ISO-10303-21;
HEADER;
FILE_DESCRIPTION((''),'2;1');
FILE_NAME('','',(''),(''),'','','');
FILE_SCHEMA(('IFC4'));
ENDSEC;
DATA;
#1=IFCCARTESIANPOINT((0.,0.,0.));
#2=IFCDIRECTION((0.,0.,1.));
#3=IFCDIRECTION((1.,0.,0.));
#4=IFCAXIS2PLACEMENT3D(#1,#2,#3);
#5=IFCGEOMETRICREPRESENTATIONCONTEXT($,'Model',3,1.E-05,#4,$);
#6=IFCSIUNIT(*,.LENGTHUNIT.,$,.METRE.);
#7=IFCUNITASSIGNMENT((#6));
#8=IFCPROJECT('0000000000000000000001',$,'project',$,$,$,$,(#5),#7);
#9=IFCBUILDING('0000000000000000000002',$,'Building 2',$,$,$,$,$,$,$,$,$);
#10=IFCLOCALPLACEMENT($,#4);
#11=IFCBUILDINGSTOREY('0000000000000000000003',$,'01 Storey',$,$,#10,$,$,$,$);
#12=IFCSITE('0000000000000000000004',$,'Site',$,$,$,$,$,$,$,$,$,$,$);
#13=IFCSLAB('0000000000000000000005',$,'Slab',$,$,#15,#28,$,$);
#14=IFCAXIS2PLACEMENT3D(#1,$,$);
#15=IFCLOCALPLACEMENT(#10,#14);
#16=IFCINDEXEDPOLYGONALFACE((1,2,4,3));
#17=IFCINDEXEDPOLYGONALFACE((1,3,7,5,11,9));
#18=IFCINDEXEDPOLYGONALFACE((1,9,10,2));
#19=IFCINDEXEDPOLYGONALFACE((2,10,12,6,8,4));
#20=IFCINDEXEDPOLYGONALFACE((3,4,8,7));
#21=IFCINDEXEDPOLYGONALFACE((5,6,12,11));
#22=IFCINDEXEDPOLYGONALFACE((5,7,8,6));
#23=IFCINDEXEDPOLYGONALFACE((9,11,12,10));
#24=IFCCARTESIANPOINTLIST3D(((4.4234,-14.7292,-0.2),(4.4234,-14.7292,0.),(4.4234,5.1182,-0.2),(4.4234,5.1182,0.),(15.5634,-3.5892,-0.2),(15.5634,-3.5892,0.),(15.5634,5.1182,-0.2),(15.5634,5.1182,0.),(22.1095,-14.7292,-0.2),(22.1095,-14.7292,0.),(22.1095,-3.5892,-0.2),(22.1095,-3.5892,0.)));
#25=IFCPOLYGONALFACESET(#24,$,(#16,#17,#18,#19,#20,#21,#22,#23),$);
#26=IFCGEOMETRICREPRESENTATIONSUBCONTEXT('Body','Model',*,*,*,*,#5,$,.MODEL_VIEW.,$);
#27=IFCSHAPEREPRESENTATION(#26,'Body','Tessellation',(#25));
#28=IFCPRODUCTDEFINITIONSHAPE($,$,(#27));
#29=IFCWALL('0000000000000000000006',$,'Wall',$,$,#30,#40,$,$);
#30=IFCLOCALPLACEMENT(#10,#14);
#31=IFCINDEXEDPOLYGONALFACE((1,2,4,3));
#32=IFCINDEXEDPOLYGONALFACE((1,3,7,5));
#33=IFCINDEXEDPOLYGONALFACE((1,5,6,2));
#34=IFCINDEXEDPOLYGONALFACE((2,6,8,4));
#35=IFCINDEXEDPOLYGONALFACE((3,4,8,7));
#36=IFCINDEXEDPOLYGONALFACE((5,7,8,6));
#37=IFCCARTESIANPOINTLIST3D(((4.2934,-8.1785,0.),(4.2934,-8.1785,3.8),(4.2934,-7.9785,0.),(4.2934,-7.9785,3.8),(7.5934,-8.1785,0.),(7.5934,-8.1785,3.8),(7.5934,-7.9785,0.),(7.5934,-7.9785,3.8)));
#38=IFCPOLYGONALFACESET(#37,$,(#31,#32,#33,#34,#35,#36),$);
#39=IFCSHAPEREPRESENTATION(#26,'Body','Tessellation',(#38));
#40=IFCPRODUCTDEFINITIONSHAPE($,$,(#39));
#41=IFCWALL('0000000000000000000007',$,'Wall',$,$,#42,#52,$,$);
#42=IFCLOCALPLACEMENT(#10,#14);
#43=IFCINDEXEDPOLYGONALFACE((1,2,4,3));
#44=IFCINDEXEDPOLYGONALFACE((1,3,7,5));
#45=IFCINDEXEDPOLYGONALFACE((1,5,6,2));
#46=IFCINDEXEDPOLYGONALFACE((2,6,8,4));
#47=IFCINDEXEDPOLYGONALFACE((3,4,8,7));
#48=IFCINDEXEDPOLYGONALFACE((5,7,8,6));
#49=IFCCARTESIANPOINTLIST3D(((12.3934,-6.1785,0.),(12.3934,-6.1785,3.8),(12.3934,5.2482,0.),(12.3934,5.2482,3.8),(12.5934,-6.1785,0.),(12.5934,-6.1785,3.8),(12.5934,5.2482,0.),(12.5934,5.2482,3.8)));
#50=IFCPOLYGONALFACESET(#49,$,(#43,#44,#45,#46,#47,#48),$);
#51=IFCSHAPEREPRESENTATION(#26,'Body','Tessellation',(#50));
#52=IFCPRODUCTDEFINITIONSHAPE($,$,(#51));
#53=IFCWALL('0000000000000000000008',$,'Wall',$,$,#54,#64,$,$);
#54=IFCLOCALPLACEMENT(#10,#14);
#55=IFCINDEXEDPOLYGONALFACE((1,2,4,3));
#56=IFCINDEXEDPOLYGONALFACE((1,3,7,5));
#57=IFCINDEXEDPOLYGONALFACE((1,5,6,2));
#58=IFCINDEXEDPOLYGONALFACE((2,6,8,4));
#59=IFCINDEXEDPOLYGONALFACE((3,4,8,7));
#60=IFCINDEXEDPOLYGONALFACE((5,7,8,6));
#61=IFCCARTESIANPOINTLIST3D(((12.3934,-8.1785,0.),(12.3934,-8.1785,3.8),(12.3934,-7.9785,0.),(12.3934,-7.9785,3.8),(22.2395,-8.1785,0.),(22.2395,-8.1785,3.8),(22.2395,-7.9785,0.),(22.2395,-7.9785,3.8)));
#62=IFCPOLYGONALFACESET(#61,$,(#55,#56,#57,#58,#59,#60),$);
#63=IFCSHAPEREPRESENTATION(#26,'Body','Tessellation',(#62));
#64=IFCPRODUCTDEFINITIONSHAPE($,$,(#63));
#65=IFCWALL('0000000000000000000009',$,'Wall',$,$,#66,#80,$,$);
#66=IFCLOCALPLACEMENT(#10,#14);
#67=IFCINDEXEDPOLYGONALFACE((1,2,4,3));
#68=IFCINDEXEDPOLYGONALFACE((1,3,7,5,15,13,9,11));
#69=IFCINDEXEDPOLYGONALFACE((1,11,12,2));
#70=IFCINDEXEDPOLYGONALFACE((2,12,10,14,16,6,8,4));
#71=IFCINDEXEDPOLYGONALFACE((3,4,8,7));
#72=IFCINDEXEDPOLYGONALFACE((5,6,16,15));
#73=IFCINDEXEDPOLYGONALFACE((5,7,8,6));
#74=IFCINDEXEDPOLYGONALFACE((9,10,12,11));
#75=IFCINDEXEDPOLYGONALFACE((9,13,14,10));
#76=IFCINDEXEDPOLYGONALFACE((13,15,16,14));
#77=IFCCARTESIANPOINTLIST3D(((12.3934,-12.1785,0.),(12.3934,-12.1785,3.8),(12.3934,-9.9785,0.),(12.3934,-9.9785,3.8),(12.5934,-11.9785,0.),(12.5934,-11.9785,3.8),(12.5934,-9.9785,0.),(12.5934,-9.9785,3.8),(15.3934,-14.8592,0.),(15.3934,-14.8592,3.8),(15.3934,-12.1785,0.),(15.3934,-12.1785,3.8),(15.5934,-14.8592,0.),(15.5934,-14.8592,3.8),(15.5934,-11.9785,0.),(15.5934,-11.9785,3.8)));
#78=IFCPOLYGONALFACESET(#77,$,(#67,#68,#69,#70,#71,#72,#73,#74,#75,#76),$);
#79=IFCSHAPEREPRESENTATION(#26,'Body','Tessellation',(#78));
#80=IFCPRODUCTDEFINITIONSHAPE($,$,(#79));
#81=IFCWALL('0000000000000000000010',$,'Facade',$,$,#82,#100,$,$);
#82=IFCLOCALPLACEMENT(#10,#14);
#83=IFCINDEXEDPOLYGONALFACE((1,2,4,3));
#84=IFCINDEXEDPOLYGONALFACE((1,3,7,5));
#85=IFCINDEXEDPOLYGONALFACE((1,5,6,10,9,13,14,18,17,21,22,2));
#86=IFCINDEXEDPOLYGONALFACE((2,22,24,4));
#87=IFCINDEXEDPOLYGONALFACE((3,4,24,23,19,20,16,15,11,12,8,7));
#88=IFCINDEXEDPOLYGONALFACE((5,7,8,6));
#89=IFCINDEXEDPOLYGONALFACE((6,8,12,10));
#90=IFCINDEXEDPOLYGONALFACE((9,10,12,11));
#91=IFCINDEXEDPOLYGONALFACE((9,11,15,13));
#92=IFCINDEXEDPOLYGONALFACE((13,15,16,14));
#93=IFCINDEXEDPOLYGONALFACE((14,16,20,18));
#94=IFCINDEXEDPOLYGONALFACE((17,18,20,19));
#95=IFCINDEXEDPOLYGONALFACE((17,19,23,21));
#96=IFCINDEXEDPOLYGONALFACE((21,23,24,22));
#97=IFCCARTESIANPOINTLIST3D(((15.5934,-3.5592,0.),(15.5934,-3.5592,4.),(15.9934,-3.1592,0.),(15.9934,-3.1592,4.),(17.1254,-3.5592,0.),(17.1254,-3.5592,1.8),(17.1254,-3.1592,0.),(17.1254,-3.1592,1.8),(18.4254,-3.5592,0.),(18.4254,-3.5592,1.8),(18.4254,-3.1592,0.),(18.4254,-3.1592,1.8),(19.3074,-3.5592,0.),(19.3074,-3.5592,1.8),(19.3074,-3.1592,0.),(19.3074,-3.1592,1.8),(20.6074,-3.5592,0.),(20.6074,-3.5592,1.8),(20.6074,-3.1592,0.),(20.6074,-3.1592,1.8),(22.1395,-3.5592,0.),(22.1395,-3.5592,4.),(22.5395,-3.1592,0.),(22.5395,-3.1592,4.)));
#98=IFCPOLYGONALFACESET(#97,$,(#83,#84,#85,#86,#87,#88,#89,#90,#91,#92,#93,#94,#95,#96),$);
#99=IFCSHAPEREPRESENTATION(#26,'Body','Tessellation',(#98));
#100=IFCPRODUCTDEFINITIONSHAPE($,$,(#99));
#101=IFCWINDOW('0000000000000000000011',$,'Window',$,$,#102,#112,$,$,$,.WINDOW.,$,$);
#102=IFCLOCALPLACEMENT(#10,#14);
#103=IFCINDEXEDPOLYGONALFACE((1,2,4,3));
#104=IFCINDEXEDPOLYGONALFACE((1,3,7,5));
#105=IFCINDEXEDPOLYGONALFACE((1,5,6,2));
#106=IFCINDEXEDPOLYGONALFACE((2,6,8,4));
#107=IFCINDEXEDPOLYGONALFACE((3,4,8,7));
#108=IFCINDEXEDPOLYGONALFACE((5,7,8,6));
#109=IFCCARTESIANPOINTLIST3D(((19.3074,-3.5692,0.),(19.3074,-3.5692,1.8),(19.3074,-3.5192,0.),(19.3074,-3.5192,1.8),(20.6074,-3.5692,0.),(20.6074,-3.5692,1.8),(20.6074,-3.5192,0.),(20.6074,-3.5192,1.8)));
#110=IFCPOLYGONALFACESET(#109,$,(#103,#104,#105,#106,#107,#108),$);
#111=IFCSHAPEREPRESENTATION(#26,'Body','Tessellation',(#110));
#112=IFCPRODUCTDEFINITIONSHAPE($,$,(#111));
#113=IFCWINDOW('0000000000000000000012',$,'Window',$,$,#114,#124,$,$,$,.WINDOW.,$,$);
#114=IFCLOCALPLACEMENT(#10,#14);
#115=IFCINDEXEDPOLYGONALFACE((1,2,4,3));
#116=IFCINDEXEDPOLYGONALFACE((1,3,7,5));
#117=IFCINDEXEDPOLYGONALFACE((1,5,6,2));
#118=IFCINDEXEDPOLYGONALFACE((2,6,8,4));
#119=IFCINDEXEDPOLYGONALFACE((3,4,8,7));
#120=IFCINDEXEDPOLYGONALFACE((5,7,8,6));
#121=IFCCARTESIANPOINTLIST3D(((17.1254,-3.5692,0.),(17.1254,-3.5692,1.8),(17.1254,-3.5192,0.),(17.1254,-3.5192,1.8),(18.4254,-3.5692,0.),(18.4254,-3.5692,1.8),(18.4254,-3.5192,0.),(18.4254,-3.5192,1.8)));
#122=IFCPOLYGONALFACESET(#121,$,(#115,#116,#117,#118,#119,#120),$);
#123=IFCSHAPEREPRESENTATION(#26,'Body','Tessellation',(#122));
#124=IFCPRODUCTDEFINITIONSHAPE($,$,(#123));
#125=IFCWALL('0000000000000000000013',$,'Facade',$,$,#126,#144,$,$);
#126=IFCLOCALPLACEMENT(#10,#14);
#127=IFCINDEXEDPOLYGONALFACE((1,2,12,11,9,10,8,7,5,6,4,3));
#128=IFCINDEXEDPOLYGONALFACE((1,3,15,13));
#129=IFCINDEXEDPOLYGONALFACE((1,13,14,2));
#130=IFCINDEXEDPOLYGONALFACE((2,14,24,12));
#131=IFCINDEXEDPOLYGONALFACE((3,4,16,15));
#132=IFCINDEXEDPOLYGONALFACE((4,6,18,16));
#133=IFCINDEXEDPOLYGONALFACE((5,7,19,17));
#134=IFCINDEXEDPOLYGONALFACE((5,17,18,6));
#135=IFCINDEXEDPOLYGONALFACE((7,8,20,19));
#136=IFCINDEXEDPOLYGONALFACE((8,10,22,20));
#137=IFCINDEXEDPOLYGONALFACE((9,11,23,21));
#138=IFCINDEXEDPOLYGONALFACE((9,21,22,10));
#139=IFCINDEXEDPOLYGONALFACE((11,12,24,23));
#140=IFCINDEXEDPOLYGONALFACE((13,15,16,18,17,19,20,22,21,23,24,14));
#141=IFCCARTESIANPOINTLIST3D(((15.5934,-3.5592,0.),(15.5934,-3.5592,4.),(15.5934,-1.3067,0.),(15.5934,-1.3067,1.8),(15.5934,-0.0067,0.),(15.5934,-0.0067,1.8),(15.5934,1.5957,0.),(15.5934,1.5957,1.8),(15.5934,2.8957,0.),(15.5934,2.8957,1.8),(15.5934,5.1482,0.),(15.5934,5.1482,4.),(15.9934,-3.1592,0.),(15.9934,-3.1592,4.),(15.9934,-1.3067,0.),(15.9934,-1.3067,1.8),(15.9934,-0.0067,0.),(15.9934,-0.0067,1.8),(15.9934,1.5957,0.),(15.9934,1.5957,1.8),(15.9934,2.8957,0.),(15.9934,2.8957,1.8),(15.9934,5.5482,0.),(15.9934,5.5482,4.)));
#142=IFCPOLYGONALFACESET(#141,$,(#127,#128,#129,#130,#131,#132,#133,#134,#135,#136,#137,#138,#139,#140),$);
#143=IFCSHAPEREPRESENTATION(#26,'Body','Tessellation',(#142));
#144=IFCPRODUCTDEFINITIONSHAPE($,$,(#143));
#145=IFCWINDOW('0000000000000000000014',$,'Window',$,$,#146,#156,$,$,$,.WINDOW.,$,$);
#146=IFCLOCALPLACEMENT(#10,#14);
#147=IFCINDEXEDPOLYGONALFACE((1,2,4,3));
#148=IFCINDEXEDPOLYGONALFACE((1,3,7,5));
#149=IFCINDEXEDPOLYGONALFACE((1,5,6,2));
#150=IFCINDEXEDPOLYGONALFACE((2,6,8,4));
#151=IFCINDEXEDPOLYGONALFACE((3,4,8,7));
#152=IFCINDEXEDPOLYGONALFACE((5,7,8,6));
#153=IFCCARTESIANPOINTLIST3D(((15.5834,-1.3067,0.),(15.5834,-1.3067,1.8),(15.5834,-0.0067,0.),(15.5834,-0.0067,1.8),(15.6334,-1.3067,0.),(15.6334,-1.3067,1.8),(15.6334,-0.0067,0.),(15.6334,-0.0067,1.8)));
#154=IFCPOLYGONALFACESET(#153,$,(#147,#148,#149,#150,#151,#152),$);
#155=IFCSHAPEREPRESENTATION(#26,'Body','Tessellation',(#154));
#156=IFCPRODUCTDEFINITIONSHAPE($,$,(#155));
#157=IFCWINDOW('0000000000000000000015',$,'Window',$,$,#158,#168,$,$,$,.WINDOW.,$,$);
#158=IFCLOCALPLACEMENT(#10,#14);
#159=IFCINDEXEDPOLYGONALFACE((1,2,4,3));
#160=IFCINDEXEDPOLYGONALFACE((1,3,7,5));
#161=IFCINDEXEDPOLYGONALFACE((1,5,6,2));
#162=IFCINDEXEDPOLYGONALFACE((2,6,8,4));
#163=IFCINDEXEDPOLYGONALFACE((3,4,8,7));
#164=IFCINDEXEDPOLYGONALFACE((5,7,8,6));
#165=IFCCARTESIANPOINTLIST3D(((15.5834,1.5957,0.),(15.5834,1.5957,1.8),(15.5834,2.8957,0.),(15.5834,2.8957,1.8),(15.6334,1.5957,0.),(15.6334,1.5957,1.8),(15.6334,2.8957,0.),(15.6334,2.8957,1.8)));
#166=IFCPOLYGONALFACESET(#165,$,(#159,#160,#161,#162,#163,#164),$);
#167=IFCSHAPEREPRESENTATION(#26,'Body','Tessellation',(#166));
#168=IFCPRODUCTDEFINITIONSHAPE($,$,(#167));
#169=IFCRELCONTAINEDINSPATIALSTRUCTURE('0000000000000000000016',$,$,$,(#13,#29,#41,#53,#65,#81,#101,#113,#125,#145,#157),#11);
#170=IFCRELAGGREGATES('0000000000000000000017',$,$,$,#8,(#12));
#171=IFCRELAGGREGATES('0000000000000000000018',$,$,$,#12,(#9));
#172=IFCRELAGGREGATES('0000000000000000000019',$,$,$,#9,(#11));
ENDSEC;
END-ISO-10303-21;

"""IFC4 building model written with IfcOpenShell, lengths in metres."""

from ifc_helpers import new_model, si_unit, origin_with_axes, place, context, subcontext, project, spatial, line, indexed_curve, outline, extrude, element, fill, save


model = new_model("IFC4")

# Units and contexts
model_context = context("Model", 3, precision=1e-05, world=origin_with_axes())
body_context = subcontext(model_context, "Body", "Model", "MODEL_VIEW")
ifc_project = project(units=[si_unit("LENGTHUNIT", "METRE")], contexts=[model_context])

# Site, building, storey
site = spatial("IfcSite", under=ifc_project, Name="Site")
building = spatial("IfcBuilding", under=site, Name="Building 2")
storey_placement = place(None, origin_with_axes())
storey = spatial("IfcBuildingStorey", under=building, at=storey_placement, Name="01 Storey")

# Slab
slab_placement = place(storey_placement, origin_with_axes())
element("IfcSlab", 1, at=slab_placement, inside=storey, Name="Slab", context=body_context, shape_type="SweptSolid", body=[
    extrude(outline(indexed_curve([(22.1095, -3.5892), (15.5634, -3.5892), (15.5634, 5.1182), (4.4234, 5.1182), (4.4234, -14.7292), (22.1095, -14.7292)], segments=[line(1, 2), line(2, 3), line(3, 4), line(4, 5), line(5, 6)])), origin_with_axes(), (0.0, 0.0, -1.0), 0.2),
])

# Walls
wall_1_placement = place(storey_placement, origin_with_axes())
element("IfcWall", 2, at=wall_1_placement, inside=storey, Name="Wall", context=body_context, shape_type="SweptSolid", body=[
    extrude(outline(indexed_curve([(7.5934, -7.9785), (4.2934, -7.9785), (4.2934, -8.1785), (7.5934, -8.1785)], segments=[line(1, 2), line(2, 3), line(3, 4)])), origin_with_axes(), (0.0, 0.0, 1.0), 3.8),
])
wall_2_placement = place(storey_placement, origin_with_axes())
element("IfcWall", 3, at=wall_2_placement, inside=storey, Name="Wall", context=body_context, shape_type="SweptSolid", body=[
    extrude(outline(indexed_curve([(12.5934, 5.2482), (12.3934, 5.2482), (12.3934, -6.1785), (12.5934, -6.1785)], segments=[line(1, 2), line(2, 3), line(3, 4)])), origin_with_axes(), (0.0, 0.0, 1.0), 3.8),
])
wall_3_placement = place(storey_placement, origin_with_axes())
element("IfcWall", 4, at=wall_3_placement, inside=storey, Name="Wall", context=body_context, shape_type="SweptSolid", body=[
    extrude(outline(indexed_curve([(22.2395, -7.9785), (12.3934, -7.9785), (12.3934, -8.1785), (22.2395, -8.1785)], segments=[line(1, 2), line(2, 3), line(3, 4)])), origin_with_axes(), (0.0, 0.0, 1.0), 3.8),
])
wall_4_placement = place(storey_placement, origin_with_axes())
element("IfcWall", 5, at=wall_4_placement, inside=storey, Name="Wall", context=body_context, shape_type="SweptSolid", body=[
    extrude(outline(indexed_curve([(15.5934, -11.9785), (12.5934, -11.9785), (12.5934, -9.9785), (12.3934, -9.9785), (12.3934, -12.1785), (15.3934, -12.1785), (15.3934, -14.8592), (15.5934, -14.8592)], segments=[line(1, 2), line(2, 3), line(3, 4), line(4, 5), line(5, 6), line(6, 7), line(7, 8)])), origin_with_axes(), (0.0, 0.0, 1.0), 3.8),
])

# Walls, openings, windows
wall_5_placement = place(storey_placement, origin_with_axes())
wall_5 = element("IfcWall", 6, at=wall_5_placement, inside=storey, Name="Facade", context=body_context, shape_type="SweptSolid", body=[
    extrude(outline(indexed_curve([(22.1395, -3.5592), (15.5934, -3.5592), (15.9934, -3.1592), (22.5395, -3.1592)], segments=[line(1, 2), line(2, 3), line(3, 4)])), origin_with_axes(), (0.0, 0.0, 1.0), 4.0),
])
opening_1_placement = place(wall_5_placement, origin_with_axes())
opening_1 = element("IfcOpeningElement", 7, at=opening_1_placement, cuts=wall_5, context=body_context, shape_type="SweptSolid", body=[
    extrude(outline(indexed_curve([(20.6074, -3.1192), (20.6074, -3.6192), (19.3074, -3.6192), (19.3074, -3.1192)], segments=[line(1, 2), line(2, 3), line(3, 4)])), origin_with_axes(), (0.0, 0.0, 1.0), 1.8),
])
opening_2_placement = place(wall_5_placement, origin_with_axes())
opening_2 = element("IfcOpeningElement", 8, at=opening_2_placement, cuts=wall_5, context=body_context, shape_type="SweptSolid", body=[
    extrude(outline(indexed_curve([(18.4254, -3.1192), (18.4254, -3.6192), (17.1254, -3.6192), (17.1254, -3.1192)], segments=[line(1, 2), line(2, 3), line(3, 4)])), origin_with_axes(), (0.0, 0.0, 1.0), 1.8),
])
window_1_placement = place(storey_placement, origin_with_axes())
window_1 = element("IfcWindow", 9, at=window_1_placement, inside=storey, Name="Window", PredefinedType="WINDOW", context=body_context, shape_type="SweptSolid", body=[
    extrude(outline(indexed_curve([(20.6074, -3.5192), (20.6074, -3.5692), (19.3074, -3.5692), (19.3074, -3.5192)], segments=[line(1, 2), line(2, 3), line(3, 4)])), origin_with_axes(), (0.0, 0.0, 1.0), 1.8),
])
fill(opening_1, window_1)
window_2_placement = place(storey_placement, origin_with_axes())
window_2 = element("IfcWindow", 10, at=window_2_placement, inside=storey, Name="Window", PredefinedType="WINDOW", context=body_context, shape_type="SweptSolid", body=[
    extrude(outline(indexed_curve([(18.4254, -3.5192), (18.4254, -3.5692), (17.1254, -3.5692), (17.1254, -3.5192)], segments=[line(1, 2), line(2, 3), line(3, 4)])), origin_with_axes(), (0.0, 0.0, 1.0), 1.8),
])
fill(opening_2, window_2)
wall_6_placement = place(storey_placement, origin_with_axes())
wall_6 = element("IfcWall", 11, at=wall_6_placement, inside=storey, Name="Facade", context=body_context, shape_type="SweptSolid", body=[
    extrude(outline(indexed_curve([(15.5934, -3.5592), (15.5934, 5.1482), (15.9934, 5.5482), (15.9934, -3.1592)], segments=[line(1, 2), line(2, 3), line(3, 4)])), origin_with_axes(), (0.0, 0.0, 1.0), 4.0),
])
opening_3_placement = place(wall_6_placement, origin_with_axes())
opening_3 = element("IfcOpeningElement", 12, at=opening_3_placement, cuts=wall_6, context=body_context, shape_type="SweptSolid", body=[
    extrude(outline(indexed_curve([(16.0334, -1.3067), (15.5334, -1.3067), (15.5334, -0.0067), (16.0334, -0.0067)], segments=[line(1, 2), line(2, 3), line(3, 4)])), origin_with_axes(), (0.0, 0.0, 1.0), 1.8),
])
opening_4_placement = place(wall_6_placement, origin_with_axes())
opening_4 = element("IfcOpeningElement", 13, at=opening_4_placement, cuts=wall_6, context=body_context, shape_type="SweptSolid", body=[
    extrude(outline(indexed_curve([(16.0334, 1.5957), (15.5334, 1.5957), (15.5334, 2.8957), (16.0334, 2.8957)], segments=[line(1, 2), line(2, 3), line(3, 4)])), origin_with_axes(), (0.0, 0.0, 1.0), 1.8),
])
window_3_placement = place(storey_placement, origin_with_axes())
window_3 = element("IfcWindow", 14, at=window_3_placement, inside=storey, Name="Window", PredefinedType="WINDOW", context=body_context, shape_type="SweptSolid", body=[
    extrude(outline(indexed_curve([(15.6334, -1.3067), (15.5834, -1.3067), (15.5834, -0.0067), (15.6334, -0.0067)], segments=[line(1, 2), line(2, 3), line(3, 4)])), origin_with_axes(), (0.0, 0.0, 1.0), 1.8),
])
fill(opening_3, window_3)
window_4_placement = place(storey_placement, origin_with_axes())
window_4 = element("IfcWindow", 15, at=window_4_placement, inside=storey, Name="Window", PredefinedType="WINDOW", context=body_context, shape_type="SweptSolid", body=[
    extrude(outline(indexed_curve([(15.6334, 1.5957), (15.5834, 1.5957), (15.5834, 2.8957), (15.6334, 2.8957)], segments=[line(1, 2), line(2, 3), line(3, 4)])), origin_with_axes(), (0.0, 0.0, 1.0), 1.8),
])
fill(opening_4, window_4)

save(model, "model.ifc")
